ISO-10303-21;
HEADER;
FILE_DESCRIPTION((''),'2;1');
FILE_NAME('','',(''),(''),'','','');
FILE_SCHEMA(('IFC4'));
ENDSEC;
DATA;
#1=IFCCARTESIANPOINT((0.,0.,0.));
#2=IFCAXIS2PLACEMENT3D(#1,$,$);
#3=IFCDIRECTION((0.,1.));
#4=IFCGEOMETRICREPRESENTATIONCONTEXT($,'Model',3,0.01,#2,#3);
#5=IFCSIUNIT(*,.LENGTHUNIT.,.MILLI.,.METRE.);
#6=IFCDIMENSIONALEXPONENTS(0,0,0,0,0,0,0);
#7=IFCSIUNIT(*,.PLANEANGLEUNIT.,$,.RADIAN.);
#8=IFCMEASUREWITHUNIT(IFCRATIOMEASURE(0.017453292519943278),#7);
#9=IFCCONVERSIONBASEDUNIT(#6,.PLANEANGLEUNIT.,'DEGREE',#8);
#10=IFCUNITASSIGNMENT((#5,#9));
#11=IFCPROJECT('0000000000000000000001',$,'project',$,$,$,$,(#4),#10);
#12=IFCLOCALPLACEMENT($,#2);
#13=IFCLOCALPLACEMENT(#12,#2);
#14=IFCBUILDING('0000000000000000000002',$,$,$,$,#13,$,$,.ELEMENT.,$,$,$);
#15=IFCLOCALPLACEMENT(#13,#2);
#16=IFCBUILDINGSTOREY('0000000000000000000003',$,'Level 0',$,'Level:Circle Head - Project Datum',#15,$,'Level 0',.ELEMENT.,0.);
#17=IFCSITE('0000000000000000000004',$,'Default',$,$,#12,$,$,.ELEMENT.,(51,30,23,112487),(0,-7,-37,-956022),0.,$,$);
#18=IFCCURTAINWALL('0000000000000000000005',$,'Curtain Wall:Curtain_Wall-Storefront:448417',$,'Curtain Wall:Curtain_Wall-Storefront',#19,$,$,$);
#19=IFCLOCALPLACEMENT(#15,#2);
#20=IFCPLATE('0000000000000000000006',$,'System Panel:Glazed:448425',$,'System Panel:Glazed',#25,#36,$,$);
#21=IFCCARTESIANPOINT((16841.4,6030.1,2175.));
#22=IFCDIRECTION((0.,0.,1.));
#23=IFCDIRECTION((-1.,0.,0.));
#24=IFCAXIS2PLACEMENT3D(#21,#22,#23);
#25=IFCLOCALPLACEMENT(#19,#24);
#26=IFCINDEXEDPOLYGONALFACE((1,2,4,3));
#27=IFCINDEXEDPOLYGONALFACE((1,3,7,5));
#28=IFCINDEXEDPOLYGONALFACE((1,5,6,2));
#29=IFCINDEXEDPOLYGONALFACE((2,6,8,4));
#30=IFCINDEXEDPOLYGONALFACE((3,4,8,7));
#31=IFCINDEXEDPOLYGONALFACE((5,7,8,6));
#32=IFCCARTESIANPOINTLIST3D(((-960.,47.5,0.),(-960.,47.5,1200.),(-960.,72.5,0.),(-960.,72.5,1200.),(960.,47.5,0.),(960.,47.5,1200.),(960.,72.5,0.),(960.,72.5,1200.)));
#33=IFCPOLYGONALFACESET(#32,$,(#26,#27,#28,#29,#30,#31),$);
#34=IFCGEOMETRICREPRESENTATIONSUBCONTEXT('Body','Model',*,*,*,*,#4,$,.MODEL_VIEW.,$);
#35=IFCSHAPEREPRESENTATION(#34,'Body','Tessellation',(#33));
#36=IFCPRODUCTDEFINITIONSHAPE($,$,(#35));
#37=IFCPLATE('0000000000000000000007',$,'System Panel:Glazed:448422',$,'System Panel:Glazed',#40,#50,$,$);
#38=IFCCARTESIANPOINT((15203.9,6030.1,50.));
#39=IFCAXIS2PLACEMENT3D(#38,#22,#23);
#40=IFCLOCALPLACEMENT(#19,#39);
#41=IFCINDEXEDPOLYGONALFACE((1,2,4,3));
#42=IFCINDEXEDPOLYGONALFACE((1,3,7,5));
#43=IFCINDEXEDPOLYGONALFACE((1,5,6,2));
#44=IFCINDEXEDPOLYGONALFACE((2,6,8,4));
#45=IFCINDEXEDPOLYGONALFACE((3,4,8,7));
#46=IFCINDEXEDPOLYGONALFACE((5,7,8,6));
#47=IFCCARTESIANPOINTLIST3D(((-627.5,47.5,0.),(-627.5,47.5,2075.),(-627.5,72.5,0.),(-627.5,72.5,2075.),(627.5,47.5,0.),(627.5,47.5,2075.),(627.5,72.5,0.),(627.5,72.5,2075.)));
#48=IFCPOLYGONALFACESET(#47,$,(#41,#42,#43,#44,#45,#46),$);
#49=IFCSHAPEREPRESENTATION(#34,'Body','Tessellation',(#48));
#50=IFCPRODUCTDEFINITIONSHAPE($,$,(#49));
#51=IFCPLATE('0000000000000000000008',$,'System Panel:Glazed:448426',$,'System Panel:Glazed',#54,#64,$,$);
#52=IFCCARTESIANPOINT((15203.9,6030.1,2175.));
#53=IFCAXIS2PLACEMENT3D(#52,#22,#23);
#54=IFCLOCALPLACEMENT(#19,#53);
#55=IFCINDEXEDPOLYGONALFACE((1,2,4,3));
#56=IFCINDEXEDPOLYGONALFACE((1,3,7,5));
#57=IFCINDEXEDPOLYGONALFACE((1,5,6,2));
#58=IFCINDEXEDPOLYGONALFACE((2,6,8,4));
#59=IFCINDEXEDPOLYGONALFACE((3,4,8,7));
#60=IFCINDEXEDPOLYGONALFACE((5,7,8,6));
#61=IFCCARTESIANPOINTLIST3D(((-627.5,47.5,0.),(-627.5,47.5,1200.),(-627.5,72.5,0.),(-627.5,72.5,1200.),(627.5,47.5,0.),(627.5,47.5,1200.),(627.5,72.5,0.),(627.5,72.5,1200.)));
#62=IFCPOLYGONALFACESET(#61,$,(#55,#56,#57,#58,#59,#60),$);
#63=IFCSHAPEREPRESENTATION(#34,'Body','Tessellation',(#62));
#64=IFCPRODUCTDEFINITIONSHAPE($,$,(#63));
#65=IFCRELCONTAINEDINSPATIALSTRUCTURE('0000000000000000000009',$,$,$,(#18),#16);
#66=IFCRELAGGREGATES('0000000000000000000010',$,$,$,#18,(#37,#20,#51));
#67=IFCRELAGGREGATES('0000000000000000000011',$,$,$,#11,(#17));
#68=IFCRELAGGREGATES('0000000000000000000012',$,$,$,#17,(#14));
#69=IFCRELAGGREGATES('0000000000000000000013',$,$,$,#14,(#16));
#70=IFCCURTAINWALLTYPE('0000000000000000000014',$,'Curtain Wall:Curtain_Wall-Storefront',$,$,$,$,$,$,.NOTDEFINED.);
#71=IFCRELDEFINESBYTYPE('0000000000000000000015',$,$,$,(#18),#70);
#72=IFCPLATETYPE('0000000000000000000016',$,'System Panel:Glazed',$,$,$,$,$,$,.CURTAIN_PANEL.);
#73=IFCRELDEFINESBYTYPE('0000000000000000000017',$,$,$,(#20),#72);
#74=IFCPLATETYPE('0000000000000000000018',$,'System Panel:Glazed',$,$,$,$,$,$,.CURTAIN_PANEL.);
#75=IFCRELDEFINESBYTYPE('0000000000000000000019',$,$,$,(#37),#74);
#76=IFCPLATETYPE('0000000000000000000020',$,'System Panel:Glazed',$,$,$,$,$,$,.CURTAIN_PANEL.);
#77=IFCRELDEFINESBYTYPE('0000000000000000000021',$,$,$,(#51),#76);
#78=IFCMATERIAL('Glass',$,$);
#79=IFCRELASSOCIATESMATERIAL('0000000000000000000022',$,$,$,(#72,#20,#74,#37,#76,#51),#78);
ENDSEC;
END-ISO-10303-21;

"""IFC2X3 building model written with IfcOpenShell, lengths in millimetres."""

from ifc_helpers import new_model, entity, si_unit, converted_unit, direction, frame, origin, origin_2d_with_axis, place, context, subcontext, project, spatial, rectangle, extrude, source, transform, mapped, material, type_object, type_shapes, element, aggregate, save


model = new_model("IFC2X3")

# Units and contexts
model_context = context("Model", 3, precision=0.01, world=origin(), true_north=direction((0.0, 1.0)))
body_context = subcontext(model_context, "Body", "Model", "MODEL_VIEW")
ifc_project = project(units=[si_unit("LENGTHUNIT", "METRE", prefix="MILLI"), converted_unit("PLANEANGLEUNIT", "DEGREE", entity("IfcRatioMeasure", 0.017453292519943278), si_unit("PLANEANGLEUNIT", "RADIAN"), dimensions=[0, 0, 0, 0, 0, 0, 0])], contexts=[model_context])

# Site, building, storey
site_placement = place(None, origin())
site = spatial("IfcSite", under=ifc_project, at=site_placement, Name="Default", CompositionType="ELEMENT", RefLatitude=(51, 30, 23, 112487), RefLongitude=(0, -7, -37, -956022), RefElevation=0.0)
building_placement = place(site_placement, origin())
building = spatial("IfcBuilding", under=site, at=building_placement, CompositionType="ELEMENT")
storey_placement = place(building_placement, origin())
storey = spatial("IfcBuildingStorey", under=building, at=storey_placement, Name="Level 0", ObjectType="Level:Circle Head - Project Datum", LongName="Level 0", CompositionType="ELEMENT", Elevation=0.0)

# Curtain wall
curtain_wall_type = type_object("IfcCurtainWallType", Name="Curtain Wall:Curtain_Wall-Storefront", PredefinedType="NOTDEFINED")
curtain_wall_1_placement = place(storey_placement, origin())
curtain_wall_1 = element("IfcCurtainWall", 1, at=curtain_wall_1_placement, inside=storey, type_object=curtain_wall_type, Name="Curtain Wall:Curtain_Wall-Storefront:448417", ObjectType="Curtain Wall:Curtain_Wall-Storefront")

# Plates
ifc_material_1 = material(Name="Glass")
plate_type_1 = type_object("IfcPlateType", Name="System Panel:Glazed", PredefinedType="CURTAIN_PANEL", material=ifc_material_1)
shared_shape_1 = source(origin(), body_context, "Body", "SweptSolid", [
    extrude(rectangle(XDim=25.0, YDim=1920.0, at=origin_2d_with_axis()), frame((0.0, 60.0, 0.0), z_axis=(0.0, 0.0, 1.0), x_axis=(0.0, 1.0, 0.0)), (0.0, 0.0, 1.0), 1200.0),
])
type_shapes(plate_type_1, [shared_shape_1])
plate_1_placement = place(curtain_wall_1_placement, frame((16841.4, 6030.1, 2175.0), z_axis=(0.0, 0.0, 1.0), x_axis=(-1.0, 0.0, 0.0)))
plate_1 = element("IfcPlate", 2, at=plate_1_placement, type_object=plate_type_1, material=ifc_material_1, Name="System Panel:Glazed:448425", ObjectType="System Panel:Glazed", context=body_context, shape_type="MappedRepresentation", body=[
    mapped(shared_shape_1, transform((0.0, 0.0, 0.0), scale=1.0)),
])
plate_type_2 = type_object("IfcPlateType", Name="System Panel:Glazed", PredefinedType="CURTAIN_PANEL", material=ifc_material_1)
shared_shape_2 = source(origin(), body_context, "Body", "SweptSolid", [
    extrude(rectangle(XDim=25.0, YDim=1255.0, at=origin_2d_with_axis()), frame((0.0, 60.0, 0.0), z_axis=(0.0, 0.0, 1.0), x_axis=(0.0, 1.0, 0.0)), (0.0, 0.0, 1.0), 2075.0),
])
type_shapes(plate_type_2, [shared_shape_2])
plate_2_placement = place(curtain_wall_1_placement, frame((15203.9, 6030.1, 50.0), z_axis=(0.0, 0.0, 1.0), x_axis=(-1.0, 0.0, 0.0)))
plate_2 = element("IfcPlate", 3, at=plate_2_placement, type_object=plate_type_2, material=ifc_material_1, Name="System Panel:Glazed:448422", ObjectType="System Panel:Glazed", context=body_context, shape_type="MappedRepresentation", body=[
    mapped(shared_shape_2, transform((0.0, 0.0, 0.0), scale=1.0)),
])
plate_type_3 = type_object("IfcPlateType", Name="System Panel:Glazed", PredefinedType="CURTAIN_PANEL", material=ifc_material_1)
shared_shape_3 = source(origin(), body_context, "Body", "SweptSolid", [
    extrude(rectangle(XDim=25.0, YDim=1255.0, at=origin_2d_with_axis()), frame((0.0, 60.0, 0.0), z_axis=(0.0, 0.0, 1.0), x_axis=(0.0, 1.0, 0.0)), (0.0, 0.0, 1.0), 1200.0),
])
type_shapes(plate_type_3, [shared_shape_3])
plate_3_placement = place(curtain_wall_1_placement, frame((15203.9, 6030.1, 2175.0), z_axis=(0.0, 0.0, 1.0), x_axis=(-1.0, 0.0, 0.0)))
plate_3 = element("IfcPlate", 4, at=plate_3_placement, type_object=plate_type_3, material=ifc_material_1, Name="System Panel:Glazed:448426", ObjectType="System Panel:Glazed", context=body_context, shape_type="MappedRepresentation", body=[
    mapped(shared_shape_3, transform((0.0, 0.0, 0.0), scale=1.0)),
])
aggregate(curtain_wall_1, [plate_2, plate_1, plate_3])

save(model, "model.ifc")
